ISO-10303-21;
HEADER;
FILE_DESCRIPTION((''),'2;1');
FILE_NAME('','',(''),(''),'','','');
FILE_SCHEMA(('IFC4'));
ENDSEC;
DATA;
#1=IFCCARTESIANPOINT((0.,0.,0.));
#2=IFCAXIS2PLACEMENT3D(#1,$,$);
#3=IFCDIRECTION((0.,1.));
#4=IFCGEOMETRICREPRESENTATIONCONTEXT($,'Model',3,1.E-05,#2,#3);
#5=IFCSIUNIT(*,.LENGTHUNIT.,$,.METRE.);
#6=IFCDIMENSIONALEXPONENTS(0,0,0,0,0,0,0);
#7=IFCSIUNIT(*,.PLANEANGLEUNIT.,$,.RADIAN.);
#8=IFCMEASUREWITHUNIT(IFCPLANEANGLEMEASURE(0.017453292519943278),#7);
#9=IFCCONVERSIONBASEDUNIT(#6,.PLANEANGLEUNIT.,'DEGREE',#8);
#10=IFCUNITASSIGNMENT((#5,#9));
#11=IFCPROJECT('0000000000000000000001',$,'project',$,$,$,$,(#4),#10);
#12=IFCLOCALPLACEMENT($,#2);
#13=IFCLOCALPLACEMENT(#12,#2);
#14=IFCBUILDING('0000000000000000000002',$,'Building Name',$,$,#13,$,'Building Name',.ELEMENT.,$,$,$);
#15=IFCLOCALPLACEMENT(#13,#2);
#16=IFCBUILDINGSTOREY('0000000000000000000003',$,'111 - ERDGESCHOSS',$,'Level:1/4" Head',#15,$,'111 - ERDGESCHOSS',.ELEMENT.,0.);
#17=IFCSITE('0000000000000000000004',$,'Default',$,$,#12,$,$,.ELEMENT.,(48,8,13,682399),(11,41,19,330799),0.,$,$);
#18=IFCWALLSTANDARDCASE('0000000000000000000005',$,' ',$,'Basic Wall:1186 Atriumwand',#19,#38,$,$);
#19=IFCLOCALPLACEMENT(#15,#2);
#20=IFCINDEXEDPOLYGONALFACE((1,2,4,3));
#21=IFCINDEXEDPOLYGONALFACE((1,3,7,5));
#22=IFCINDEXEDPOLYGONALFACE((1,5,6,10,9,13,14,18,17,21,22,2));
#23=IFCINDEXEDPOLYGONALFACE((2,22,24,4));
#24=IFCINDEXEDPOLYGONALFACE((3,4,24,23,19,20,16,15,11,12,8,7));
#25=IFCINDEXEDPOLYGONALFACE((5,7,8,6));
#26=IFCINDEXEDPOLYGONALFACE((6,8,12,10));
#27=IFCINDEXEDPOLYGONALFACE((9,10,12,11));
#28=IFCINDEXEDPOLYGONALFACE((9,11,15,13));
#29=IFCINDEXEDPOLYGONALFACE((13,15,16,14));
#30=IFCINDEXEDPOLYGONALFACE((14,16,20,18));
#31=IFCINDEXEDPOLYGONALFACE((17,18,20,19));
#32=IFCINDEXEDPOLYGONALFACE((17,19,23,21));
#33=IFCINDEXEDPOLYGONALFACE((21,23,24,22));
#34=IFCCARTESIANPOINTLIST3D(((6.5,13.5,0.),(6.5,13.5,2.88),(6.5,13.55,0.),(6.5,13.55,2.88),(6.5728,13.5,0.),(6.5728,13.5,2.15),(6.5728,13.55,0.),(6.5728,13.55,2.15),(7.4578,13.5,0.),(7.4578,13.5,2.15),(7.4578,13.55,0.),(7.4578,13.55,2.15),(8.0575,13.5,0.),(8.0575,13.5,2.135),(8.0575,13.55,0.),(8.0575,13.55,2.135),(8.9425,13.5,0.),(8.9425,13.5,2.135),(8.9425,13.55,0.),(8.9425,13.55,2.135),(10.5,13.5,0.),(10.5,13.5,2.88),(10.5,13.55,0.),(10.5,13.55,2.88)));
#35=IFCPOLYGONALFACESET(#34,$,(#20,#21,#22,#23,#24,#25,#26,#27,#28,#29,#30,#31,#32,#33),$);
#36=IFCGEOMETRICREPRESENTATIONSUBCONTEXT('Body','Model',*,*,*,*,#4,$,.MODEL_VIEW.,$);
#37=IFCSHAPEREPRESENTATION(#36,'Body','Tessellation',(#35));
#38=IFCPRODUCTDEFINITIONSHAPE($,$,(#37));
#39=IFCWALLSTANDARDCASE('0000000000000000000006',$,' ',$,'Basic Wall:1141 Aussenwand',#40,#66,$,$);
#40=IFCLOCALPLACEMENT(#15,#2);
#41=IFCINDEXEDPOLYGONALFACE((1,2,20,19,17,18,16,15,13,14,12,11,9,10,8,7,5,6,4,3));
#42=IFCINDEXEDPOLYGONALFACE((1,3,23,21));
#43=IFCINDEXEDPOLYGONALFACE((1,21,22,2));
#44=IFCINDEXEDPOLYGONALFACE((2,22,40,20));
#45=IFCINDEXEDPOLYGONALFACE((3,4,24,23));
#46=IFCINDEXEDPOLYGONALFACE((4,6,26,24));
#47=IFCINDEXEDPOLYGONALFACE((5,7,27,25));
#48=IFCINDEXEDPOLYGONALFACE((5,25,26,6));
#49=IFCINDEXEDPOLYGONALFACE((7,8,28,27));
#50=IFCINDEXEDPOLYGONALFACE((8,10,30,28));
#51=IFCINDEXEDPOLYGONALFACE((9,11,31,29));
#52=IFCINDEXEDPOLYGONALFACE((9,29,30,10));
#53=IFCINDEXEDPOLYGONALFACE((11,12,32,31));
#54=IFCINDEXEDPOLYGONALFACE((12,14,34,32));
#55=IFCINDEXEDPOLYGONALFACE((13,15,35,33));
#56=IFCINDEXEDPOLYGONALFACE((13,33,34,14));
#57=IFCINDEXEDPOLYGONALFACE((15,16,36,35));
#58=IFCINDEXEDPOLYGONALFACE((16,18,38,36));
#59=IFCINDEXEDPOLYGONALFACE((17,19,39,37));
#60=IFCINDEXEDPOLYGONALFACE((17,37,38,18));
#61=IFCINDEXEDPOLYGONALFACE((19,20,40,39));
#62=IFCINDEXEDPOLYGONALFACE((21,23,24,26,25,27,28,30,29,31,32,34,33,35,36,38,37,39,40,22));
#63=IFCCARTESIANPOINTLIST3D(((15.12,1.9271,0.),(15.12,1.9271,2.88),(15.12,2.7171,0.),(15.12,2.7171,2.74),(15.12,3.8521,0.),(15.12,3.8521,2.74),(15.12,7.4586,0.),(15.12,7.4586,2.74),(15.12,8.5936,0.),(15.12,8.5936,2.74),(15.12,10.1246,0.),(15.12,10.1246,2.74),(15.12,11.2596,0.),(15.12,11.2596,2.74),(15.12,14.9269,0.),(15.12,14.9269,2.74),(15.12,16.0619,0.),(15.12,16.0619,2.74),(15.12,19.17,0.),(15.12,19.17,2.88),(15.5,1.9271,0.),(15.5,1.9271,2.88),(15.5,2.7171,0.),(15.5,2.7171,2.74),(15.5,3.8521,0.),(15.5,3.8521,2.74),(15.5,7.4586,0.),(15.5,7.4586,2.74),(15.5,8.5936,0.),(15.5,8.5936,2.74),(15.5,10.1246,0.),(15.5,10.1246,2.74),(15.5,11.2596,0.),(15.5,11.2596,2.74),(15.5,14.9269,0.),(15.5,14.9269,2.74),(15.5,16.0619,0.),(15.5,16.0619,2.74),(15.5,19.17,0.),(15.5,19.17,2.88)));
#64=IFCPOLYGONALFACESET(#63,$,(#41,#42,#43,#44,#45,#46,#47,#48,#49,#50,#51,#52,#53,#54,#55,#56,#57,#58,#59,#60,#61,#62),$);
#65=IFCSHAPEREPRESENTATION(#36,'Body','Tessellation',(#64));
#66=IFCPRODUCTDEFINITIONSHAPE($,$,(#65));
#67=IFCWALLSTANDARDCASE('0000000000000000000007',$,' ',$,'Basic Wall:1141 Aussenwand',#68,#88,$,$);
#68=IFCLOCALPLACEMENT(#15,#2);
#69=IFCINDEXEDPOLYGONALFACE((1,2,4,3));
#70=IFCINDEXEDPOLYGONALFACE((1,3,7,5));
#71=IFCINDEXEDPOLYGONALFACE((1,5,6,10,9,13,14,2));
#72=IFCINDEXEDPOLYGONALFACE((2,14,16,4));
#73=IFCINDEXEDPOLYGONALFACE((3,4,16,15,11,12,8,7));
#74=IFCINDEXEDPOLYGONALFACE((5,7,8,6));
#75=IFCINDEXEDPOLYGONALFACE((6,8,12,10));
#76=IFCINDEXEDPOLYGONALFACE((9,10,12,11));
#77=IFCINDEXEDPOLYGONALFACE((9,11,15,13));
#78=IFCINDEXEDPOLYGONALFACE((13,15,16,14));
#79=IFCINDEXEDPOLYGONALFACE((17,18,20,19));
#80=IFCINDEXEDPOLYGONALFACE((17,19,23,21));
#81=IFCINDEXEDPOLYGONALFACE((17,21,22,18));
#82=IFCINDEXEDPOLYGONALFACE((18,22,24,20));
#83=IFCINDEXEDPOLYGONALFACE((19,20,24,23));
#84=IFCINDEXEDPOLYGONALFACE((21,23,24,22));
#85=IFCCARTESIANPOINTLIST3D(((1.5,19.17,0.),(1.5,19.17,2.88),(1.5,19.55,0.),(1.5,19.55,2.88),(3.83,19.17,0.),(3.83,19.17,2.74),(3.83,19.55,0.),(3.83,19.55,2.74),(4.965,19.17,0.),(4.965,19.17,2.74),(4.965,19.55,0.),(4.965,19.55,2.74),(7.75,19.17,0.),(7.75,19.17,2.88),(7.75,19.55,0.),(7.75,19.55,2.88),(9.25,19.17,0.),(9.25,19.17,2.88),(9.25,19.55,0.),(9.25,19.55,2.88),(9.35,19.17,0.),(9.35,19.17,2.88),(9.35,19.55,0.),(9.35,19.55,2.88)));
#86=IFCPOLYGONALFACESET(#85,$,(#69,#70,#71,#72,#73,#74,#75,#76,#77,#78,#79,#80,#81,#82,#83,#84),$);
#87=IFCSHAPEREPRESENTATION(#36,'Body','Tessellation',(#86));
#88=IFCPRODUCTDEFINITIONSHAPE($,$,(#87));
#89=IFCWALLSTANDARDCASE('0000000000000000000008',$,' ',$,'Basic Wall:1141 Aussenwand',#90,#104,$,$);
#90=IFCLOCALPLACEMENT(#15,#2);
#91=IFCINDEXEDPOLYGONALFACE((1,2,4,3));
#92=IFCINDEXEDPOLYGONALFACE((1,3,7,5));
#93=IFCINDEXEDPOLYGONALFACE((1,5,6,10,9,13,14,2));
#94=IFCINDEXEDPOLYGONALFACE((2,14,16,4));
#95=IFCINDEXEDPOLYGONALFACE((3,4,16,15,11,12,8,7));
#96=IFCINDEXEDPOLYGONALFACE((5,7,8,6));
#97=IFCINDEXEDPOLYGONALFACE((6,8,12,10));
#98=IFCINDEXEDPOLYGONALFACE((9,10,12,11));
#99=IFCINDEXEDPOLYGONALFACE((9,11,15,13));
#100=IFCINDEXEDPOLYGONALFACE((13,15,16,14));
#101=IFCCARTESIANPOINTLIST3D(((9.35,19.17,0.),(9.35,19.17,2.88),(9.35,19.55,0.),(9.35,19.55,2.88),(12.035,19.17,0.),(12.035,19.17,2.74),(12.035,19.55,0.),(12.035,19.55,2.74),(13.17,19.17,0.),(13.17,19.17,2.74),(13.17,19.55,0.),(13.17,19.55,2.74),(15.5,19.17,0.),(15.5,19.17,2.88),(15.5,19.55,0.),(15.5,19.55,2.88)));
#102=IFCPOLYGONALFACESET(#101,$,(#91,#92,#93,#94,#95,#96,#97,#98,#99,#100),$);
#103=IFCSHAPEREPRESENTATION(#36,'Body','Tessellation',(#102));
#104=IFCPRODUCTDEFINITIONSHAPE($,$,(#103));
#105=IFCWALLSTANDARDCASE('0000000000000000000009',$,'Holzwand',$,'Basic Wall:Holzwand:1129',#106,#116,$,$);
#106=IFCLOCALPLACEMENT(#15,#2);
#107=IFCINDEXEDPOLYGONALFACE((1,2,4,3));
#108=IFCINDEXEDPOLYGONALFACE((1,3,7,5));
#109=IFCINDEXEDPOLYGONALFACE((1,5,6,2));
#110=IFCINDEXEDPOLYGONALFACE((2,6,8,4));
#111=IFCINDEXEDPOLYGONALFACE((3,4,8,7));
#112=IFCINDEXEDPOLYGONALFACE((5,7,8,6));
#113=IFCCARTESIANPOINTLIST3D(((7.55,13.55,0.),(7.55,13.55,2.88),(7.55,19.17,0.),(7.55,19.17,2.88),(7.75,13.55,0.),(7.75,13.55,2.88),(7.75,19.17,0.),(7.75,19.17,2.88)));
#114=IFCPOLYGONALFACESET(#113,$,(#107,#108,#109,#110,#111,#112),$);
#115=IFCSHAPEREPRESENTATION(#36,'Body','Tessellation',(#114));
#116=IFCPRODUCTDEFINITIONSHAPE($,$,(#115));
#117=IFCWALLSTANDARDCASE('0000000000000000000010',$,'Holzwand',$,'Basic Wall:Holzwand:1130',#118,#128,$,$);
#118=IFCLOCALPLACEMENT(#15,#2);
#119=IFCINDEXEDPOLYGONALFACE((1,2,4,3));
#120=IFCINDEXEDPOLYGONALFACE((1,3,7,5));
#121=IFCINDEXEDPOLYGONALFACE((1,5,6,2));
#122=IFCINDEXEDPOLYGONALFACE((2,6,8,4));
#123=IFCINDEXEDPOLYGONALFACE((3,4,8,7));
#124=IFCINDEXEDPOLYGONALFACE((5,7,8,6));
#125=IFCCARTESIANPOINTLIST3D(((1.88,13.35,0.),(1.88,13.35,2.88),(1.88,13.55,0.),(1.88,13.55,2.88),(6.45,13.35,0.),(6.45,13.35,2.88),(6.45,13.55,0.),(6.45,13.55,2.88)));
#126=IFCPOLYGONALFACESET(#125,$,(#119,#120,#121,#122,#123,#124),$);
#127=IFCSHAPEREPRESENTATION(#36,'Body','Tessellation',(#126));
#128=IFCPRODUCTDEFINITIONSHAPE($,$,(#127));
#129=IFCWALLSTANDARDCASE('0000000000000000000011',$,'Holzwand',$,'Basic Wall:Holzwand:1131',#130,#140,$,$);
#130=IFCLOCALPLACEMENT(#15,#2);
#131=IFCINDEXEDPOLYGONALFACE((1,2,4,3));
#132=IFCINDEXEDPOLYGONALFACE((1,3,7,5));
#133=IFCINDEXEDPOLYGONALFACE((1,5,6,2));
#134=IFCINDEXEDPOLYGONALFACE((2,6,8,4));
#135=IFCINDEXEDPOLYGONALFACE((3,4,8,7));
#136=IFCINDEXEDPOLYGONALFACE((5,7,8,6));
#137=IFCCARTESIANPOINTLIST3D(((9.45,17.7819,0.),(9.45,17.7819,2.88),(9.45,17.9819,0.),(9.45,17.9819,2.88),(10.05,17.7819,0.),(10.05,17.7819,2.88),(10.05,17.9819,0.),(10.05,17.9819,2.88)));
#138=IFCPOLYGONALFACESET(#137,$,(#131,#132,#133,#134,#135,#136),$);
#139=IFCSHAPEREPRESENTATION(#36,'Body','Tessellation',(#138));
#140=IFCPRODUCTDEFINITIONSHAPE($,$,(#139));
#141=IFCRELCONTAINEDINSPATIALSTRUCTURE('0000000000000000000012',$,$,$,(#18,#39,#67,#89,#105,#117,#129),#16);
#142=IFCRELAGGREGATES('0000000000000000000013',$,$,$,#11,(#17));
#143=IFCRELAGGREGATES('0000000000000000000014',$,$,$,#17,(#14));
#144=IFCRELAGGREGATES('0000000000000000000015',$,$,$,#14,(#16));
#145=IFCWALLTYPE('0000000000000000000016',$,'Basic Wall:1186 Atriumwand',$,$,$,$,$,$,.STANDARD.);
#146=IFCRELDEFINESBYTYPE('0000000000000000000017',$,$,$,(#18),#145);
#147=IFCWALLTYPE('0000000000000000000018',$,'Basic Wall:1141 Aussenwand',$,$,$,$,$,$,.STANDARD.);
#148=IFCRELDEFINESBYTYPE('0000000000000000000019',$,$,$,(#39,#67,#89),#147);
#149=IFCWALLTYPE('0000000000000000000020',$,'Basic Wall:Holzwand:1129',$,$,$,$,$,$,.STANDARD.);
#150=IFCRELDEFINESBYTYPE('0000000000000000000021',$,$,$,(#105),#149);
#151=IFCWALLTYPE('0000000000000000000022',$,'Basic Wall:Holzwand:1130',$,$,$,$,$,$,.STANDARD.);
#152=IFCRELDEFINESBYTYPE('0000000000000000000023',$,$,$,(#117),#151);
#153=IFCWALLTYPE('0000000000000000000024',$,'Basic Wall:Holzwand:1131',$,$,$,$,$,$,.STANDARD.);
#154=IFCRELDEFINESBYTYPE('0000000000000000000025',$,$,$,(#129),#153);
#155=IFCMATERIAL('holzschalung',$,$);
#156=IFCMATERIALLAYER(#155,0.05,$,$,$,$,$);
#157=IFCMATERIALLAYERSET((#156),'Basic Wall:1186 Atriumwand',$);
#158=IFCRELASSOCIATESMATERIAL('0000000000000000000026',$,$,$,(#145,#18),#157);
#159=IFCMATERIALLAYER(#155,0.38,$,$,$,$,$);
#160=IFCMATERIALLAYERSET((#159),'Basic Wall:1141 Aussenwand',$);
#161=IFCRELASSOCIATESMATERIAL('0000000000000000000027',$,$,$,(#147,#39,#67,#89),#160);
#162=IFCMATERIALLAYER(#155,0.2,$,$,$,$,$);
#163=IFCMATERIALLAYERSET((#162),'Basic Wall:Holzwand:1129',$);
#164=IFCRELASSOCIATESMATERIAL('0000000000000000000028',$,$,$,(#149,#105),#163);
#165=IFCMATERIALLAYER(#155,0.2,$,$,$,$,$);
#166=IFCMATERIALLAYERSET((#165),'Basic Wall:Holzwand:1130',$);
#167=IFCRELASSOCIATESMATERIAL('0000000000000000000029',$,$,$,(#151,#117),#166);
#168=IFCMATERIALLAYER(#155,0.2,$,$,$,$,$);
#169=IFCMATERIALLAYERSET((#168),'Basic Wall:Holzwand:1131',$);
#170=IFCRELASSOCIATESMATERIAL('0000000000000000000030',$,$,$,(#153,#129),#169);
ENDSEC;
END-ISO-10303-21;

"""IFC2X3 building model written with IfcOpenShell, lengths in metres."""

from ifc_helpers import new_model, entity, si_unit, converted_unit, direction, frame, frame_2d, origin, origin_2d_with_axis, place, context, subcontext, project, spatial, rectangle, extrude, material, layer, layer_set, layer_usage, type_object, element, save


model = new_model("IFC2X3")

# Units and contexts
model_context = context("Model", 3, precision=1e-05, world=origin(), true_north=direction((0.0, 1.0)))
body_context = subcontext(model_context, "Body", "Model", "MODEL_VIEW")
ifc_project = project(units=[si_unit("LENGTHUNIT", "METRE"), converted_unit("PLANEANGLEUNIT", "DEGREE", entity("IfcPlaneAngleMeasure", 0.017453292519943278), si_unit("PLANEANGLEUNIT", "RADIAN"), dimensions=[0, 0, 0, 0, 0, 0, 0])], contexts=[model_context])

# Site, building, storey
site_placement = place(None, origin())
site = spatial("IfcSite", under=ifc_project, at=site_placement, Name="Default", CompositionType="ELEMENT", RefLatitude=(48, 8, 13, 682399), RefLongitude=(11, 41, 19, 330799), RefElevation=0.0)
building_placement = place(site_placement, origin())
building = spatial("IfcBuilding", under=site, at=building_placement, Name="Building Name", LongName="Building Name", CompositionType="ELEMENT")
storey_placement = place(building_placement, origin())
storey = spatial("IfcBuildingStorey", under=building, at=storey_placement, Name="111 - ERDGESCHOSS", ObjectType="Level:1/4\" Head", LongName="111 - ERDGESCHOSS", CompositionType="ELEMENT", Elevation=0.0)

# Walls, openings
ifc_material = material(Name="holzschalung")
ifc_layer_1 = layer(ifc_material, 0.05)
ifc_layer_set_1 = layer_set([ifc_layer_1], Name="Basic Wall:1186 Atriumwand")
ifc_layer_usage_1 = layer_usage(ifc_layer_set_1, "AXIS2", "NEGATIVE", 0.025)
wall_type_1 = type_object("IfcWallType", Name="Basic Wall:1186 Atriumwand", PredefinedType="STANDARD", material=ifc_layer_set_1)
wall_1_placement = place(storey_placement, frame((6.5, 13.525, 0.0)))
wall_1 = element("IfcWallStandardCase", 1, at=wall_1_placement, inside=storey, type_object=wall_type_1, material=ifc_layer_usage_1, Name=" ", ObjectType="Basic Wall:1186 Atriumwand", context=body_context, shape_type="SweptSolid", body=[
    extrude(rectangle(XDim=4.0, YDim=0.05, at=frame_2d((2.0, 0.0), x_axis=(1.0, 0.0))), origin(), (0.0, 0.0, 1.0), 2.88),
])
opening_1_placement = place(wall_1_placement, frame((-6.5, -13.525, 0.0)))
element("IfcOpeningElement", 2, at=opening_1_placement, cuts=wall_1, ObjectType="Opening", context=body_context, shape_type="SweptSolid", body=[
    extrude(rectangle(XDim=2.3, YDim=0.885, at=origin_2d_with_axis()), frame((7.0153, 13.4995, 1.0), z_axis=(0.0, 1.0, 0.0), x_axis=(0.0, 0.0, 1.0)), (0.0, 0.0, 1.0), 0.051),
])
opening_2_placement = place(wall_1_placement, frame((-6.5, -13.525, 0.0)))
element("IfcOpeningElement", 3, at=opening_2_placement, cuts=wall_1, ObjectType="Opening", context=body_context, shape_type="SweptSolid", body=[
    extrude(rectangle(XDim=2.135, YDim=0.885, at=frame_2d((0.0, 0.0), x_axis=(0.0, 1.0))), frame((8.5, 13.4995, 1.0675), z_axis=(0.0, 1.0, 0.0), x_axis=(-1.0, 0.0, 0.0)), (0.0, 0.0, 1.0), 0.051),
])
ifc_layer_2 = layer(ifc_material, 0.38)
ifc_layer_set_2 = layer_set([ifc_layer_2], Name="Basic Wall:1141 Aussenwand")
ifc_layer_usage_2 = layer_usage(ifc_layer_set_2, "AXIS2", "NEGATIVE", 0.19)
wall_type_2 = type_object("IfcWallType", Name="Basic Wall:1141 Aussenwand", PredefinedType="STANDARD", material=ifc_layer_set_2)
wall_2_placement = place(storey_placement, frame((15.31, 19.17, 0.0), z_axis=(0.0, 0.0, 1.0), x_axis=(0.0, -1.0, 0.0)))
wall_2 = element("IfcWallStandardCase", 4, at=wall_2_placement, inside=storey, type_object=wall_type_2, material=ifc_layer_usage_2, Name=" ", ObjectType="Basic Wall:1141 Aussenwand", context=body_context, shape_type="SweptSolid", body=[
    extrude(rectangle(XDim=17.2429, YDim=0.38, at=frame_2d((8.6214, 0.0), x_axis=(-1.0, 0.0))), origin(), (0.0, 0.0, 1.0), 2.88),
])
opening_3_placement = place(wall_2_placement, origin())
element("IfcOpeningElement", 5, at=opening_3_placement, cuts=wall_2, ObjectType="Opening", context=body_context, shape_type="SweptSolid", body=[
    extrude(rectangle(XDim=2.74, YDim=1.135, at=frame_2d((0.0, 0.0), x_axis=(0.0, 1.0))), frame((15.8854, -0.19, 1.37), z_axis=(0.0, 1.0, 0.0), x_axis=(-1.0, 0.0, 0.0)), (0.0, 0.0, 1.0), 0.38),
])
opening_4_placement = place(wall_2_placement, origin())
element("IfcOpeningElement", 6, at=opening_4_placement, cuts=wall_2, ObjectType="Opening", context=body_context, shape_type="SweptSolid", body=[
    extrude(rectangle(XDim=2.74, YDim=1.135, at=frame_2d((0.0, 0.0), x_axis=(0.0, 1.0))), frame((11.1439, -0.19, 1.37), z_axis=(0.0, 1.0, 0.0), x_axis=(-1.0, 0.0, 0.0)), (0.0, 0.0, 1.0), 0.38),
])
opening_5_placement = place(wall_2_placement, origin())
element("IfcOpeningElement", 7, at=opening_5_placement, cuts=wall_2, ObjectType="Opening", context=body_context, shape_type="SweptSolid", body=[
    extrude(rectangle(XDim=2.74, YDim=1.135, at=frame_2d((0.0, 0.0), x_axis=(0.0, 1.0))), frame((8.4779, -0.19, 1.37), z_axis=(0.0, 1.0, 0.0), x_axis=(-1.0, 0.0, 0.0)), (0.0, 0.0, 1.0), 0.38),
])
opening_6_placement = place(wall_2_placement, origin())
element("IfcOpeningElement", 8, at=opening_6_placement, cuts=wall_2, ObjectType="Opening", context=body_context, shape_type="SweptSolid", body=[
    extrude(rectangle(XDim=2.74, YDim=1.135, at=frame_2d((0.0, 0.0), x_axis=(0.0, 1.0))), frame((3.6756, -0.19, 1.37), z_axis=(0.0, 1.0, 0.0), x_axis=(-1.0, 0.0, 0.0)), (0.0, 0.0, 1.0), 0.38),
])
ifc_layer_usage_3 = layer_usage(ifc_layer_set_2, "AXIS2", "NEGATIVE", 0.19)
wall_3_placement = place(storey_placement, frame((1.5, 19.36, 0.0)))
wall_3 = element("IfcWallStandardCase", 9, at=wall_3_placement, inside=storey, type_object=wall_type_2, material=ifc_layer_usage_3, Name=" ", ObjectType="Basic Wall:1141 Aussenwand", context=body_context, shape_type="SweptSolid", body=[
    extrude(rectangle(XDim=7.85, YDim=0.38, at=frame_2d((3.925, 0.0), x_axis=(-1.0, 0.0))), origin(), (0.0, 0.0, 1.0), 2.88),
])
opening_7_placement = place(wall_3_placement, origin())
element("IfcOpeningElement", 10, at=opening_7_placement, cuts=wall_3, ObjectType="Opening", context=body_context, shape_type="SweptSolid", body=[
    extrude(rectangle(XDim=2.74, YDim=1.135, at=frame_2d((0.0, 0.0), x_axis=(1.0, 0.0))), frame((2.8975, -0.19, 1.37), z_axis=(0.0, 1.0, 0.0), x_axis=(0.0, 0.0, 1.0)), (0.0, 0.0, 1.0), 0.38),
])
opening_8_placement = place(wall_3_placement, frame((-1.5, -19.36, 0.0)))
element("IfcOpeningElement", 11, at=opening_8_placement, cuts=wall_3, ObjectType="Opening", context=body_context, shape_type="SweptSolid", body=[
    extrude(rectangle(XDim=3.03, YDim=1.5, at=frame_2d((0.0, 0.0), x_axis=(0.0, 1.0))), frame((8.5, 19.1662, 1.365), z_axis=(0.0, 1.0, 0.0), x_axis=(-1.0, 0.0, 0.0)), (0.0, 0.0, 1.0), 0.3876),
])

# Wall, opening
ifc_layer_usage_4 = layer_usage(ifc_layer_set_2, "AXIS2", "NEGATIVE", 0.19)
wall_4_placement = place(storey_placement, frame((9.35, 19.36, 0.0)))
wall_4 = element("IfcWallStandardCase", 12, at=wall_4_placement, inside=storey, type_object=wall_type_2, material=ifc_layer_usage_4, Name=" ", ObjectType="Basic Wall:1141 Aussenwand", context=body_context, shape_type="SweptSolid", body=[
    extrude(rectangle(XDim=6.15, YDim=0.38, at=frame_2d((3.075, 0.0), x_axis=(-1.0, 0.0))), origin(), (0.0, 0.0, 1.0), 2.88),
])
opening_9_placement = place(wall_4_placement, origin())
element("IfcOpeningElement", 13, at=opening_9_placement, cuts=wall_4, ObjectType="Opening", context=body_context, shape_type="SweptSolid", body=[
    extrude(rectangle(XDim=2.74, YDim=1.135, at=origin_2d_with_axis()), frame((3.2525, -0.19, 1.37), z_axis=(0.0, 1.0, 0.0), x_axis=(0.0, 0.0, 1.0)), (0.0, 0.0, 1.0), 0.38),
])

# Walls
ifc_layer_3 = layer(ifc_material, 0.2)
ifc_layer_set_3 = layer_set([ifc_layer_3], Name="Basic Wall:Holzwand:1129")
ifc_layer_usage_5 = layer_usage(ifc_layer_set_3, "AXIS2", "NEGATIVE", 0.1)
wall_type_3 = type_object("IfcWallType", Name="Basic Wall:Holzwand:1129", PredefinedType="STANDARD", material=ifc_layer_set_3)
wall_5_placement = place(storey_placement, frame((7.65, 13.55, 0.0), z_axis=(0.0, 0.0, 1.0), x_axis=(0.0, 1.0, 0.0)))
element("IfcWallStandardCase", 14, at=wall_5_placement, inside=storey, type_object=wall_type_3, material=ifc_layer_usage_5, Name="Holzwand", ObjectType="Basic Wall:Holzwand:1129", context=body_context, shape_type="SweptSolid", body=[
    extrude(rectangle(XDim=5.62, YDim=0.2, at=frame_2d((2.81, 0.0), x_axis=(-1.0, 0.0))), origin(), (0.0, 0.0, 1.0), 2.88),
])
ifc_layer_4 = layer(ifc_material, 0.2)
ifc_layer_set_4 = layer_set([ifc_layer_4], Name="Basic Wall:Holzwand:1130")
ifc_layer_usage_6 = layer_usage(ifc_layer_set_4, "AXIS2", "NEGATIVE", 0.1)
wall_type_4 = type_object("IfcWallType", Name="Basic Wall:Holzwand:1130", PredefinedType="STANDARD", material=ifc_layer_set_4)
wall_6_placement = place(storey_placement, frame((1.88, 13.45, 0.0)))
element("IfcWallStandardCase", 15, at=wall_6_placement, inside=storey, type_object=wall_type_4, material=ifc_layer_usage_6, Name="Holzwand", ObjectType="Basic Wall:Holzwand:1130", context=body_context, shape_type="SweptSolid", body=[
    extrude(rectangle(XDim=4.57, YDim=0.2, at=frame_2d((2.285, 0.0), x_axis=(-1.0, 0.0))), origin(), (0.0, 0.0, 1.0), 2.88),
])
ifc_layer_5 = layer(ifc_material, 0.2)
ifc_layer_set_5 = layer_set([ifc_layer_5], Name="Basic Wall:Holzwand:1131")
ifc_layer_usage_7 = layer_usage(ifc_layer_set_5, "AXIS2", "NEGATIVE", 0.1)
wall_type_5 = type_object("IfcWallType", Name="Basic Wall:Holzwand:1131", PredefinedType="STANDARD", material=ifc_layer_set_5)
wall_7_placement = place(storey_placement, frame((10.05, 17.8819, 0.0), z_axis=(0.0, 0.0, 1.0), x_axis=(-1.0, 0.0, 0.0)))
element("IfcWallStandardCase", 16, at=wall_7_placement, inside=storey, type_object=wall_type_5, material=ifc_layer_usage_7, Name="Holzwand", ObjectType="Basic Wall:Holzwand:1131", context=body_context, shape_type="SweptSolid", body=[
    extrude(rectangle(XDim=0.6, YDim=0.2, at=frame_2d((0.3, 0.0), x_axis=(-1.0, 0.0))), origin(), (0.0, 0.0, 1.0), 2.88),
])

save(model, "model.ifc")
